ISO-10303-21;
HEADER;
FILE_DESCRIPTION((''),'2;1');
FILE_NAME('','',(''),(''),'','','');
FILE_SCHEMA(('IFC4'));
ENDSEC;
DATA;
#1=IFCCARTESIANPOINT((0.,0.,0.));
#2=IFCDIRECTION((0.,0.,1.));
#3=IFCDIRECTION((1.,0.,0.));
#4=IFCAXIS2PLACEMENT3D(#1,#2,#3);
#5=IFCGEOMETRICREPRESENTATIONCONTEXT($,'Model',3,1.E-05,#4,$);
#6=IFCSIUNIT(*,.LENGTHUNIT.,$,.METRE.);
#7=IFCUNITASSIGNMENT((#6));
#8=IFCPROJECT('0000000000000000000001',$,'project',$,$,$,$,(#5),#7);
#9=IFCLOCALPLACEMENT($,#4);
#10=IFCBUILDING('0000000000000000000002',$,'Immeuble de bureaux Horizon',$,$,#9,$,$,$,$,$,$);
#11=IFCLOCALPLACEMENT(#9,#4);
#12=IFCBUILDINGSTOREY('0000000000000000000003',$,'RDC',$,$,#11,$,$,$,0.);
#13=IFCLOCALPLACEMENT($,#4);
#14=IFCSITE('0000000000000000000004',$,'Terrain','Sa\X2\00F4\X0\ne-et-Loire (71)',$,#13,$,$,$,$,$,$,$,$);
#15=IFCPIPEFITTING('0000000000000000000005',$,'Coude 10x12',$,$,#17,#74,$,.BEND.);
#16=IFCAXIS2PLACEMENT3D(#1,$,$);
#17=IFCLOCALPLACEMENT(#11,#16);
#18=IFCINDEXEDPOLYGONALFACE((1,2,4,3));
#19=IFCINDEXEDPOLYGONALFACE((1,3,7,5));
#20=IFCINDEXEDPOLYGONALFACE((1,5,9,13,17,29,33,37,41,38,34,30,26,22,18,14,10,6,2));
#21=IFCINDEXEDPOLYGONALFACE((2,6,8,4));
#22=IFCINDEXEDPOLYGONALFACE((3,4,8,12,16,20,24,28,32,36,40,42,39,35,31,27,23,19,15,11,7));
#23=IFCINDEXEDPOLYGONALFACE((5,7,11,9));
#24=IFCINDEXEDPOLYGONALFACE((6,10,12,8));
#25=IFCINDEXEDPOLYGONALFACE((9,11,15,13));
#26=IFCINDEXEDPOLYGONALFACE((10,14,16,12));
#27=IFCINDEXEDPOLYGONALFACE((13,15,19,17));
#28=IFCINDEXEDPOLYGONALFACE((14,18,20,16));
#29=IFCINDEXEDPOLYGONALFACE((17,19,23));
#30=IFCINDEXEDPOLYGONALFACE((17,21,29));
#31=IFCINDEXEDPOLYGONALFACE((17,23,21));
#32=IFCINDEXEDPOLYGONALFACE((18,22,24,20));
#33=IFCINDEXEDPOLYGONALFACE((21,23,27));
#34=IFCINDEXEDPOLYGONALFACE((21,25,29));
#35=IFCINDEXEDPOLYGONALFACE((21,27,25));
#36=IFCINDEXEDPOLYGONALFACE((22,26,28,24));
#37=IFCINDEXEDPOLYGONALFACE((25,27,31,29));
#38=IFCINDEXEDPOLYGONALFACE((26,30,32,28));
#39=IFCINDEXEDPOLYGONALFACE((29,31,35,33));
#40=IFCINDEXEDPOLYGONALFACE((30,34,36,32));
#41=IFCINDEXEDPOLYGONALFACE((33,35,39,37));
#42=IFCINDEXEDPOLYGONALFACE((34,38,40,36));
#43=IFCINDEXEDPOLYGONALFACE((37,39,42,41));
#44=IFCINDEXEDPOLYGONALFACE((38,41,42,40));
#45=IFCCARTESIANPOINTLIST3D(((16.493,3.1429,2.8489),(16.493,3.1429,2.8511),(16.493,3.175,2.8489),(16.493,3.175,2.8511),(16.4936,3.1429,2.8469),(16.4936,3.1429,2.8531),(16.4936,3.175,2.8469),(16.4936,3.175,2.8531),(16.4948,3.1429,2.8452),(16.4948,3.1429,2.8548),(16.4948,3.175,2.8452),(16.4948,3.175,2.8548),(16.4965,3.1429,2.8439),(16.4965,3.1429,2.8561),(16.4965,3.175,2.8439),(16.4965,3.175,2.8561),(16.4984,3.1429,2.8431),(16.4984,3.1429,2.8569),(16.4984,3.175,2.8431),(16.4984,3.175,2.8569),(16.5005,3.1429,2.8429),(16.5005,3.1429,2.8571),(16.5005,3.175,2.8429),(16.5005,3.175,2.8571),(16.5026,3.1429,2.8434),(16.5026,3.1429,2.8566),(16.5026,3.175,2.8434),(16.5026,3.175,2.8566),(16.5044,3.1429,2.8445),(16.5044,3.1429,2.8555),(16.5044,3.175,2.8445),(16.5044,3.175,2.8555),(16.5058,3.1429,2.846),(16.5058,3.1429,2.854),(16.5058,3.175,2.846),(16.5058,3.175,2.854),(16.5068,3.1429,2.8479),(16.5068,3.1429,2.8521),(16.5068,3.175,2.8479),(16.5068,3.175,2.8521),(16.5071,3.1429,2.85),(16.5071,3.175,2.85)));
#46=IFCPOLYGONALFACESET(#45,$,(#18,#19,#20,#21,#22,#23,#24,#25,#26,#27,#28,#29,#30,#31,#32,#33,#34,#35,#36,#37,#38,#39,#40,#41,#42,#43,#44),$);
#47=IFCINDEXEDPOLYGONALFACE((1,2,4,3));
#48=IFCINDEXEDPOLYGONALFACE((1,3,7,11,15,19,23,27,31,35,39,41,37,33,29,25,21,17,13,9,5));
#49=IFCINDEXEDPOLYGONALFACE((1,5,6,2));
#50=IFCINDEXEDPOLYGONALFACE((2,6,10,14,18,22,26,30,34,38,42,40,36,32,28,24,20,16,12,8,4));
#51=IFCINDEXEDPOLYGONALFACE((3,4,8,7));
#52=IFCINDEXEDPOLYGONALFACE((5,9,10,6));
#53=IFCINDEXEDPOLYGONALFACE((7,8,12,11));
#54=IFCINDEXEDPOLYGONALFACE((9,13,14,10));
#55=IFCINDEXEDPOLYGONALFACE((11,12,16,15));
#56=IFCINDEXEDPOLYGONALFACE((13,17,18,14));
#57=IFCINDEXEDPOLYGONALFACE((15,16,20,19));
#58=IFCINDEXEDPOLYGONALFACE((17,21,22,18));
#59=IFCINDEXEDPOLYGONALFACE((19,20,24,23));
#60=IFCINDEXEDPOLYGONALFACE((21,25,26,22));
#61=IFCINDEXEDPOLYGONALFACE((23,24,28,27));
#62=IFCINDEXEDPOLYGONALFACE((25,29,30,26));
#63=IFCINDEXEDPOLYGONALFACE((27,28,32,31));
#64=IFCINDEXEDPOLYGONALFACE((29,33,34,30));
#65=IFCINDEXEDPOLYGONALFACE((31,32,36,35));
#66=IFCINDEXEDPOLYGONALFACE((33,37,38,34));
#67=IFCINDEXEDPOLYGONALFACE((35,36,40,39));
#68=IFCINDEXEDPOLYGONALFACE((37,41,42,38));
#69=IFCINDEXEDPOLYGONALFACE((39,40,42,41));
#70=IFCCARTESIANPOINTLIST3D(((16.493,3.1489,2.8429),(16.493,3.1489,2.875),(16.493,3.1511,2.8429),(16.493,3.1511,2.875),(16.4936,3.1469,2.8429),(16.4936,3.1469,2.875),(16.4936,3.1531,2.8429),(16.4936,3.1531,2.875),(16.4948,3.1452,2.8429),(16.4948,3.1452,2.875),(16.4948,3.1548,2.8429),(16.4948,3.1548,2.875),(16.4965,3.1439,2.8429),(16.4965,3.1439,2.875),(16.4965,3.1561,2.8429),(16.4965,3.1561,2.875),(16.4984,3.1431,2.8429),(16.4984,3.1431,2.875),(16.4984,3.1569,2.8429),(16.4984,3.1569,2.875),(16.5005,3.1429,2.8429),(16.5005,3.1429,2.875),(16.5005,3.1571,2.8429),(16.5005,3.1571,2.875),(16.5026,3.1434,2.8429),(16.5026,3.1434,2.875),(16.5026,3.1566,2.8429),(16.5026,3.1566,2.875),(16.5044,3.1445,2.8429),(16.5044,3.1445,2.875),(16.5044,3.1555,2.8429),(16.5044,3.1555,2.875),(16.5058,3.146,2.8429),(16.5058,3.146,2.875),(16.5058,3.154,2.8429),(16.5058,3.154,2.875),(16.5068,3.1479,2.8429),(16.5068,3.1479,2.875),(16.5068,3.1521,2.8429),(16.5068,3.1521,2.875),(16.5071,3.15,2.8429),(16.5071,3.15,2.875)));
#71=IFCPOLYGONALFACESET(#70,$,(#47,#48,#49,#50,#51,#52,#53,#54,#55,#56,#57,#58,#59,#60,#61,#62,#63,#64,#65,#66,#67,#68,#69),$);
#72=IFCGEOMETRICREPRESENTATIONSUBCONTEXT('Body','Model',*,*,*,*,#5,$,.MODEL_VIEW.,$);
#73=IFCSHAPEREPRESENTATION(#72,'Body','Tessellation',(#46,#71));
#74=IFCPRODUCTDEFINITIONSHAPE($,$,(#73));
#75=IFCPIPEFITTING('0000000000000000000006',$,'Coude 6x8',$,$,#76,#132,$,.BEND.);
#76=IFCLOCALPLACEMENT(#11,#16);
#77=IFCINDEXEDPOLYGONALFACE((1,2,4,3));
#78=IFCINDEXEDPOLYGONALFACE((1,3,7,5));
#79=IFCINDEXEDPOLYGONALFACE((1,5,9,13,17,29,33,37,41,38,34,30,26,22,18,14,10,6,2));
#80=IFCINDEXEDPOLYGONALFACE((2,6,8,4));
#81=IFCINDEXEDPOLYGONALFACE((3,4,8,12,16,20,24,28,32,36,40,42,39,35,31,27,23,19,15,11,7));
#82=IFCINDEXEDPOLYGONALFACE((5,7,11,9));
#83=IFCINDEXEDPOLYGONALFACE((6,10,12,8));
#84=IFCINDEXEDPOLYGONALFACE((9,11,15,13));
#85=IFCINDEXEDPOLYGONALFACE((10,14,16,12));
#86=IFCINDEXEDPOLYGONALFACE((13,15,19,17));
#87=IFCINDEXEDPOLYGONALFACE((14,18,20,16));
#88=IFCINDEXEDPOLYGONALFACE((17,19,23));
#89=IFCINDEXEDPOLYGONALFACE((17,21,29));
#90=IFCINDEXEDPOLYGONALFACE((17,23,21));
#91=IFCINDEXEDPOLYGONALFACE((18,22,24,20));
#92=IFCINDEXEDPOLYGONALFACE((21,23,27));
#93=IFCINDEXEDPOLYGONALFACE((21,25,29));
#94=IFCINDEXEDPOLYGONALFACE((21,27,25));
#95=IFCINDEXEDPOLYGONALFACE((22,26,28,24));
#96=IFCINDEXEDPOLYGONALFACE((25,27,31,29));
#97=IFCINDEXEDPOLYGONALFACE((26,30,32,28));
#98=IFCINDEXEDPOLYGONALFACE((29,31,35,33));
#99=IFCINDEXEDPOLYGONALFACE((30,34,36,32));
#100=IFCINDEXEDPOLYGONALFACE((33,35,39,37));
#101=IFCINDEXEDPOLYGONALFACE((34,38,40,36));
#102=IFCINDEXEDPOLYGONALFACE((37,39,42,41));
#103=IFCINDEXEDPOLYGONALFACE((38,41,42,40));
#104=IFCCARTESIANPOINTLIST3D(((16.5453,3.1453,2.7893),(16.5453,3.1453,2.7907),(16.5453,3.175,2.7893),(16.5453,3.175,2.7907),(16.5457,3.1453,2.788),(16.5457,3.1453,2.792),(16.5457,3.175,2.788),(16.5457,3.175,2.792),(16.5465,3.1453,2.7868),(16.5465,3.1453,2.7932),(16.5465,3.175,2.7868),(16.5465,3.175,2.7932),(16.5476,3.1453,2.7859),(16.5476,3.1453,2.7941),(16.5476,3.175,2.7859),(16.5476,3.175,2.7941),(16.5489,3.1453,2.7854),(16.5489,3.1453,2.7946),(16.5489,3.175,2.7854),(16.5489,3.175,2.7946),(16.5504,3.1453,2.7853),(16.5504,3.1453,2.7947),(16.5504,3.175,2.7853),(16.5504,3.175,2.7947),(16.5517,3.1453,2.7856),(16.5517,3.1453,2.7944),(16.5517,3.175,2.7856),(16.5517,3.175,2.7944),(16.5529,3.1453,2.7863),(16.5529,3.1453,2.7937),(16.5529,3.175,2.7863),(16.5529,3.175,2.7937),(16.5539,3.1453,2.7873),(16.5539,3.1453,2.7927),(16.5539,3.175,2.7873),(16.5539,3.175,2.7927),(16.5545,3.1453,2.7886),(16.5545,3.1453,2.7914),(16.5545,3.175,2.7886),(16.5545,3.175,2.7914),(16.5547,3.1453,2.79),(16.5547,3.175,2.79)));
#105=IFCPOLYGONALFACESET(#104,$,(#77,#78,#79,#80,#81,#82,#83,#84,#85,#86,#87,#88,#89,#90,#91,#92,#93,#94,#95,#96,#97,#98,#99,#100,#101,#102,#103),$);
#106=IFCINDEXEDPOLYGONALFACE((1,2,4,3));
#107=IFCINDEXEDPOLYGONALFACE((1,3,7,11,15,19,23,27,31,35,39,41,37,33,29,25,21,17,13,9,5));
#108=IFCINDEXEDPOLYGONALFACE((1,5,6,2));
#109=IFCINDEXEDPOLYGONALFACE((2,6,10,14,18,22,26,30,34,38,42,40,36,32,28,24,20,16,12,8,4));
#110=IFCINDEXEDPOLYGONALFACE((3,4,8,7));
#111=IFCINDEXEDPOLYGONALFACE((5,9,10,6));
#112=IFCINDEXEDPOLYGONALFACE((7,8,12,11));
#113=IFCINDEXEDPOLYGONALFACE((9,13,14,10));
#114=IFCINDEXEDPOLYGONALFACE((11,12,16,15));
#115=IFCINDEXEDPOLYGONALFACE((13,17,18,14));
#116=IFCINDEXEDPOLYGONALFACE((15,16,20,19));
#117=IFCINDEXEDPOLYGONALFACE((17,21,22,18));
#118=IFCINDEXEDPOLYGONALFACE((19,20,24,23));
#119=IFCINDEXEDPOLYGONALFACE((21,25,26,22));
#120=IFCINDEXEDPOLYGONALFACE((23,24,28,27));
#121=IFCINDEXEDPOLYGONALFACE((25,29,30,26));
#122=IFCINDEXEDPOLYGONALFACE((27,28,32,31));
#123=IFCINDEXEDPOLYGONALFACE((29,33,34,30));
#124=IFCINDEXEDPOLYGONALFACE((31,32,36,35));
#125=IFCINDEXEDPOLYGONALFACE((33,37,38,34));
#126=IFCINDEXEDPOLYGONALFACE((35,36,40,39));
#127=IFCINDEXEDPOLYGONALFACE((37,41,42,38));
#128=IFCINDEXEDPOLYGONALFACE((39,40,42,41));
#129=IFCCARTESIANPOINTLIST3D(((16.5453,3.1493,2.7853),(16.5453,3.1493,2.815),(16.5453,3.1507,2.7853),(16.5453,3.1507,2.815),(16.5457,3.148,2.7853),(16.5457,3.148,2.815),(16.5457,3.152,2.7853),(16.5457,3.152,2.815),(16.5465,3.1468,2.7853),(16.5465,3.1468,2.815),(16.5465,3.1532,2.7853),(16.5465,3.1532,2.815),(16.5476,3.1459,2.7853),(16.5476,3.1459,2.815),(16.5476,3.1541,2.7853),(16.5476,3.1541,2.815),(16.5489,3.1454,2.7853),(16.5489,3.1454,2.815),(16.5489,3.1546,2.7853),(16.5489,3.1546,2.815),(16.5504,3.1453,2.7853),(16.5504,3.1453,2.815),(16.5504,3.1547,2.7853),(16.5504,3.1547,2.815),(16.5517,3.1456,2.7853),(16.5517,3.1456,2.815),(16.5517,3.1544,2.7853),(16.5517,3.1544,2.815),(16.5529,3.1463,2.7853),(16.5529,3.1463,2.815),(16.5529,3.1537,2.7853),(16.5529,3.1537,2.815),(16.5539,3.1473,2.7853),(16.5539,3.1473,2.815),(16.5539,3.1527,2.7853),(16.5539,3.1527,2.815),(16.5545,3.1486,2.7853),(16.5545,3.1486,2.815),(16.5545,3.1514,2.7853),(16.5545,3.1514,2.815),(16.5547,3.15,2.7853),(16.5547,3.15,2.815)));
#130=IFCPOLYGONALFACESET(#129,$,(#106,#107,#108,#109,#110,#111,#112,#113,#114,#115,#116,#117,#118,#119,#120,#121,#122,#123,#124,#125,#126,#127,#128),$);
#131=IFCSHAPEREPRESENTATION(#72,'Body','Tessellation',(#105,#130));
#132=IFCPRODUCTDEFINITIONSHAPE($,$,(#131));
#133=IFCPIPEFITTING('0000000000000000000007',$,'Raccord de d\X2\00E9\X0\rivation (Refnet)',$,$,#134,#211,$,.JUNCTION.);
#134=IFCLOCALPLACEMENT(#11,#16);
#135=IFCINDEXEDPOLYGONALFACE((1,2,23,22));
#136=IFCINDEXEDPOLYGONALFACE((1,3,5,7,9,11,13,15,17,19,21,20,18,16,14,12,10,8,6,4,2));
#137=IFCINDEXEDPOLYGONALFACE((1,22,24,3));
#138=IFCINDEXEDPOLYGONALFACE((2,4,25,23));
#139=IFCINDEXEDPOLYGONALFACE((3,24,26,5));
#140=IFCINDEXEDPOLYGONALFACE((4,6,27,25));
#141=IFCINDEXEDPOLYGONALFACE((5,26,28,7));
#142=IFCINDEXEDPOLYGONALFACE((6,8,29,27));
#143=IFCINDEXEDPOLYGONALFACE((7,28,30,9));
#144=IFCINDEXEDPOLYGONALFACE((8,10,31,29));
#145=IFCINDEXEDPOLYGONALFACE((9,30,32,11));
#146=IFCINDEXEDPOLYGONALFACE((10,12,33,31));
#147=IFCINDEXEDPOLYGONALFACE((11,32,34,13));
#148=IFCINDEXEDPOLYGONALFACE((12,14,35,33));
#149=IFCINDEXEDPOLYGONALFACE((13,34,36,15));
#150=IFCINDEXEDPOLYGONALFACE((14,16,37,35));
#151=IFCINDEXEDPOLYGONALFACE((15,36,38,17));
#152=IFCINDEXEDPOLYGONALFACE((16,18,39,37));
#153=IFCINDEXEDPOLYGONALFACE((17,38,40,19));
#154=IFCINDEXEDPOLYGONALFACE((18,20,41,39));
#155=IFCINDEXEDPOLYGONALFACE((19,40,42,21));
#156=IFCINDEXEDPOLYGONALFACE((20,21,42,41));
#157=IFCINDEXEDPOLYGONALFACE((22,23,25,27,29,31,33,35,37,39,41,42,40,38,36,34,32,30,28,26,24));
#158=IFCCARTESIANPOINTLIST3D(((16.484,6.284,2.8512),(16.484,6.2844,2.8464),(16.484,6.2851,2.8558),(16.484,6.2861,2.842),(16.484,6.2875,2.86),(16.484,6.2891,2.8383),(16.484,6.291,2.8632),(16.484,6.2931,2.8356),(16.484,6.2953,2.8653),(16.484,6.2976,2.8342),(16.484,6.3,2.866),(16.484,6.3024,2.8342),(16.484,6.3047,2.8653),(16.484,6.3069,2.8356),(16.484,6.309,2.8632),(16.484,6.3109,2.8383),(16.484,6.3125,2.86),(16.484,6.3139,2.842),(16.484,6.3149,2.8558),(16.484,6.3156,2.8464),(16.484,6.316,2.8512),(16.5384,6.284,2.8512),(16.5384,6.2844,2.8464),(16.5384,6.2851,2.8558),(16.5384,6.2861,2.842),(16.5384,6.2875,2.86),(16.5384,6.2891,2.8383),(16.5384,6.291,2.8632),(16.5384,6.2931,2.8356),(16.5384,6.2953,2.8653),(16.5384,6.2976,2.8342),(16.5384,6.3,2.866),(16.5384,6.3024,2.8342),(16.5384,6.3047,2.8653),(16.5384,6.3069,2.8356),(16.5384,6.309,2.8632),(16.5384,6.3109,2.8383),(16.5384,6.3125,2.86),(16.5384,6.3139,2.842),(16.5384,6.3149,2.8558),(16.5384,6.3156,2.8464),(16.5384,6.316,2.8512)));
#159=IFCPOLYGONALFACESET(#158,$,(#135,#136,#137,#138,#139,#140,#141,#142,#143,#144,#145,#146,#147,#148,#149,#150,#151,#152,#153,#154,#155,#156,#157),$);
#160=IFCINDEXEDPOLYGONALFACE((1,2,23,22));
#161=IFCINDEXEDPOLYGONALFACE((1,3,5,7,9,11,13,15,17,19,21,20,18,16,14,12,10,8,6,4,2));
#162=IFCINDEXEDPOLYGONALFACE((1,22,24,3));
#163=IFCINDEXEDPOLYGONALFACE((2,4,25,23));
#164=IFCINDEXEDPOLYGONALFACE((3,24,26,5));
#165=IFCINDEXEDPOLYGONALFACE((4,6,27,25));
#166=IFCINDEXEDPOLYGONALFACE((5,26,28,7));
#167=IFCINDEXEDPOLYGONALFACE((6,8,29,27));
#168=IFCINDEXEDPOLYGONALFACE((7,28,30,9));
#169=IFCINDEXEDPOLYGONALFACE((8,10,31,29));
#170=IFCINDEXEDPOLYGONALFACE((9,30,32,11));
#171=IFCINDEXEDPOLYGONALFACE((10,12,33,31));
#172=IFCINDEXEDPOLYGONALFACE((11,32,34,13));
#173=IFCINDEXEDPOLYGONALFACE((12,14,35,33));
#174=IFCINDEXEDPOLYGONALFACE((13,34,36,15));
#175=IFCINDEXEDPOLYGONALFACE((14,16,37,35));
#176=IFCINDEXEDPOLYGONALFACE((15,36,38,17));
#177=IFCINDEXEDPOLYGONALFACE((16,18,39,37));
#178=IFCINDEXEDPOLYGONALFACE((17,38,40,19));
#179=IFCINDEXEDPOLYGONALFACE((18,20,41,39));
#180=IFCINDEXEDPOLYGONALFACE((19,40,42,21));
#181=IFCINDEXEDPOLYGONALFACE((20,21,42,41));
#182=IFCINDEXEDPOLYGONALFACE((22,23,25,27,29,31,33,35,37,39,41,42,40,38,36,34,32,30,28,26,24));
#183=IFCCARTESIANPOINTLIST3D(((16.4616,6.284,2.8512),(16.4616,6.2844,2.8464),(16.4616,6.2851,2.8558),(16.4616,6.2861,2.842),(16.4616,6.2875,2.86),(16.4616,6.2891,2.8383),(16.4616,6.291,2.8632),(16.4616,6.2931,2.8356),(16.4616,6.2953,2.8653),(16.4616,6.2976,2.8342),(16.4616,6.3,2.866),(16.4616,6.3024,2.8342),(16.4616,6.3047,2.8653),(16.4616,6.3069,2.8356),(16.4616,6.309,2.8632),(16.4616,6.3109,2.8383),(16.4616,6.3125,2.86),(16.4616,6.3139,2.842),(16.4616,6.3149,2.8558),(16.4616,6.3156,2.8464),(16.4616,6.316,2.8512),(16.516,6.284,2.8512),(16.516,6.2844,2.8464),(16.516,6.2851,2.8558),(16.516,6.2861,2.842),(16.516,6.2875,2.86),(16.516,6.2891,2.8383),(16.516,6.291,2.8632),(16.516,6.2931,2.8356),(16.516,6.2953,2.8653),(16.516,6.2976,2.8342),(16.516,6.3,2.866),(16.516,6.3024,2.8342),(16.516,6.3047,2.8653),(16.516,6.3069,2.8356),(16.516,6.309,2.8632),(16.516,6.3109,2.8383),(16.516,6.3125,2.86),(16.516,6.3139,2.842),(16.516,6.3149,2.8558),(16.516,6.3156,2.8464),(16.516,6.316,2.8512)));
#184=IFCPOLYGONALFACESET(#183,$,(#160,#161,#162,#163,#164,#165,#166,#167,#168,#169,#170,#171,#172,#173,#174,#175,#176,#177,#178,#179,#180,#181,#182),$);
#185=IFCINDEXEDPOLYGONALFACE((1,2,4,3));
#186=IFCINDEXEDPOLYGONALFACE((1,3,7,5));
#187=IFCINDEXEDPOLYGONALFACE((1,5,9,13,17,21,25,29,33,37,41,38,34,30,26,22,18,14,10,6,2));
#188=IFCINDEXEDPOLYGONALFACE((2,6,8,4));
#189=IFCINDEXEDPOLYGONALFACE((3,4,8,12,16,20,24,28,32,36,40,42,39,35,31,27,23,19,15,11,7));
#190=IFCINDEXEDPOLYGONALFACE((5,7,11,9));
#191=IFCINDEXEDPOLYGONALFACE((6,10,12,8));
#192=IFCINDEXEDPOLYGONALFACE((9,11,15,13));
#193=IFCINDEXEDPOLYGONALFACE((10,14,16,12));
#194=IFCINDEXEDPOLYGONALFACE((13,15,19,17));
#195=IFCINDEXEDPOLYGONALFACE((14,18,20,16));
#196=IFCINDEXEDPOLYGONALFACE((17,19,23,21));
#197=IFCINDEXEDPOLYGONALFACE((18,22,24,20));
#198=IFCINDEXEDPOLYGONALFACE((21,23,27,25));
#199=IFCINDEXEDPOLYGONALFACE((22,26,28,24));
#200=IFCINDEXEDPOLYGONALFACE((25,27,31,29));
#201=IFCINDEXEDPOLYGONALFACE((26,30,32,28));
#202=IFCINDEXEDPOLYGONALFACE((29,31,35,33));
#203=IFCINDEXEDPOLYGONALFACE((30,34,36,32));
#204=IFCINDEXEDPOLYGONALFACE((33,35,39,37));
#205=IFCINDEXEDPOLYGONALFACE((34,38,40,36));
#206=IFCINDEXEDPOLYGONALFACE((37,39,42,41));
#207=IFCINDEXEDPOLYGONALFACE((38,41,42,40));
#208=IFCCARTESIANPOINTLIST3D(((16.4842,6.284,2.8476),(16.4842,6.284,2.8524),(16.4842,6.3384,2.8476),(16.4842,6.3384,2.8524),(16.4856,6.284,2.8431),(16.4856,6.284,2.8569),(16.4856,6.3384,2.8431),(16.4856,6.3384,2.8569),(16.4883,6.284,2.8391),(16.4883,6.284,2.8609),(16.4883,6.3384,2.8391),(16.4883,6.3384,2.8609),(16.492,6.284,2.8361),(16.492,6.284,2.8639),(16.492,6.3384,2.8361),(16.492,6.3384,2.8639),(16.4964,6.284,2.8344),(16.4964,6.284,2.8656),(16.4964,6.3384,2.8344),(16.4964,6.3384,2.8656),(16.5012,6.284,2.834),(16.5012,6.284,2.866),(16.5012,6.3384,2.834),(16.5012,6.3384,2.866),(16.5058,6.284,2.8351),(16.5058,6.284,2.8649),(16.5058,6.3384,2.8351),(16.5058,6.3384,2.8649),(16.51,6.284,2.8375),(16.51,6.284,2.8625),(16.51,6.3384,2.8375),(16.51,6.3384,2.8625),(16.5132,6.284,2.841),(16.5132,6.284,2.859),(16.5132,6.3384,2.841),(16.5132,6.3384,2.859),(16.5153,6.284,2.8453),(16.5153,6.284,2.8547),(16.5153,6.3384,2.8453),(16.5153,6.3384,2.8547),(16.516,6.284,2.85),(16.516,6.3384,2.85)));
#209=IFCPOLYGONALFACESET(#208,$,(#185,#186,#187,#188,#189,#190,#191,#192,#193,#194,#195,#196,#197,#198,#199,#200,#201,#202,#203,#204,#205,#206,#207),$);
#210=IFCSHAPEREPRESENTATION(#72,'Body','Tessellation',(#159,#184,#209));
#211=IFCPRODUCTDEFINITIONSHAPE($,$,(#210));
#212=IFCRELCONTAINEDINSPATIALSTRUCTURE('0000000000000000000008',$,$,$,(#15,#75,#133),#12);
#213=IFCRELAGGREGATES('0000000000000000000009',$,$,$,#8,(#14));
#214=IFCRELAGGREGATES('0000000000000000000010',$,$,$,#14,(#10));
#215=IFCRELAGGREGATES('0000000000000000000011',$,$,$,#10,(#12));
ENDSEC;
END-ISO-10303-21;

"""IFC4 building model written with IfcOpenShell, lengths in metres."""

from ifc_helpers import new_model, si_unit, frame, origin_with_axes, place, context, subcontext, project, spatial, circle, extrude, element, save


model = new_model("IFC4")

# Units and contexts
model_context = context("Model", 3, precision=1e-05, world=origin_with_axes())
body_context = subcontext(model_context, "Body", "Model", "MODEL_VIEW")
ifc_project = project(units=[si_unit("LENGTHUNIT", "METRE")], contexts=[model_context])

# Site, building, storey
site_placement = place(None, origin_with_axes())
site = spatial("IfcSite", under=ifc_project, at=site_placement, Name="Terrain", Description="Saône-et-Loire (71)")
building_placement = place(None, origin_with_axes())
building = spatial("IfcBuilding", under=site, at=building_placement, Name="Immeuble de bureaux Horizon")
storey_placement = place(building_placement, origin_with_axes())
storey = spatial("IfcBuildingStorey", under=building, at=storey_placement, Name="RDC", Elevation=0.0)

# Pipe fittings
pipe_fitting_1_placement = place(storey_placement, frame((16.5, 3.15, 2.85), z_axis=(0.0, 0.0, 1.0), x_axis=(1.0, 0.0, 0.0)))
element("IfcPipeFitting", 1, at=pipe_fitting_1_placement, inside=storey, Name="Coude 10x12", PredefinedType="BEND", context=body_context, shape_type="SweptSolid", body=[
    extrude(circle(Radius=0.0071), frame((0.0, -0.0071, 0.0), z_axis=(0.0, 1.0, 0.0), x_axis=(1.0, 0.0, 0.0)), (0.0, 0.0, 1.0), 0.0321),
    extrude(circle(Radius=0.0071), frame((0.0, 0.0, -0.0071), z_axis=(0.0, 0.0, 1.0), x_axis=(1.0, 0.0, 0.0)), (0.0, 0.0, 1.0), 0.0321),
])
pipe_fitting_2_placement = place(storey_placement, frame((16.55, 3.15, 2.79), z_axis=(0.0, 0.0, 1.0), x_axis=(1.0, 0.0, 0.0)))
element("IfcPipeFitting", 2, at=pipe_fitting_2_placement, inside=storey, Name="Coude 6x8", PredefinedType="BEND", context=body_context, shape_type="SweptSolid", body=[
    extrude(circle(Radius=0.0047), frame((0.0, -0.0047, 0.0), z_axis=(0.0, 1.0, 0.0), x_axis=(1.0, 0.0, 0.0)), (0.0, 0.0, 1.0), 0.0297),
    extrude(circle(Radius=0.0047), frame((0.0, 0.0, -0.0047), z_axis=(0.0, 0.0, 1.0), x_axis=(1.0, 0.0, 0.0)), (0.0, 0.0, 1.0), 0.0297),
])
pipe_fitting_3_placement = place(storey_placement, frame((16.5, 6.3, 2.85), z_axis=(0.0, 0.0, 1.0), x_axis=(1.0, 0.0, 0.0)))
element("IfcPipeFitting", 3, at=pipe_fitting_3_placement, inside=storey, Name="Raccord de dérivation (Refnet)", PredefinedType="JUNCTION", context=body_context, shape_type="SweptSolid", body=[
    extrude(circle(Radius=0.016), frame((-0.016, 0.0, 0.0), z_axis=(1.0, 0.0, 0.0), x_axis=(0.0, 0.0, 1.0)), (0.0, 0.0, 1.0), 0.0544),
    extrude(circle(Radius=0.016), frame((0.016, 0.0, 0.0), z_axis=(-1.0, 0.0, 0.0), x_axis=(0.0, 0.0, 1.0)), (0.0, 0.0, 1.0), 0.0544),
    extrude(circle(Radius=0.016), frame((0.0, -0.016, 0.0), z_axis=(0.0, 1.0, 0.0), x_axis=(1.0, 0.0, 0.0)), (0.0, 0.0, 1.0), 0.0544),
])

save(model, "model.ifc")
